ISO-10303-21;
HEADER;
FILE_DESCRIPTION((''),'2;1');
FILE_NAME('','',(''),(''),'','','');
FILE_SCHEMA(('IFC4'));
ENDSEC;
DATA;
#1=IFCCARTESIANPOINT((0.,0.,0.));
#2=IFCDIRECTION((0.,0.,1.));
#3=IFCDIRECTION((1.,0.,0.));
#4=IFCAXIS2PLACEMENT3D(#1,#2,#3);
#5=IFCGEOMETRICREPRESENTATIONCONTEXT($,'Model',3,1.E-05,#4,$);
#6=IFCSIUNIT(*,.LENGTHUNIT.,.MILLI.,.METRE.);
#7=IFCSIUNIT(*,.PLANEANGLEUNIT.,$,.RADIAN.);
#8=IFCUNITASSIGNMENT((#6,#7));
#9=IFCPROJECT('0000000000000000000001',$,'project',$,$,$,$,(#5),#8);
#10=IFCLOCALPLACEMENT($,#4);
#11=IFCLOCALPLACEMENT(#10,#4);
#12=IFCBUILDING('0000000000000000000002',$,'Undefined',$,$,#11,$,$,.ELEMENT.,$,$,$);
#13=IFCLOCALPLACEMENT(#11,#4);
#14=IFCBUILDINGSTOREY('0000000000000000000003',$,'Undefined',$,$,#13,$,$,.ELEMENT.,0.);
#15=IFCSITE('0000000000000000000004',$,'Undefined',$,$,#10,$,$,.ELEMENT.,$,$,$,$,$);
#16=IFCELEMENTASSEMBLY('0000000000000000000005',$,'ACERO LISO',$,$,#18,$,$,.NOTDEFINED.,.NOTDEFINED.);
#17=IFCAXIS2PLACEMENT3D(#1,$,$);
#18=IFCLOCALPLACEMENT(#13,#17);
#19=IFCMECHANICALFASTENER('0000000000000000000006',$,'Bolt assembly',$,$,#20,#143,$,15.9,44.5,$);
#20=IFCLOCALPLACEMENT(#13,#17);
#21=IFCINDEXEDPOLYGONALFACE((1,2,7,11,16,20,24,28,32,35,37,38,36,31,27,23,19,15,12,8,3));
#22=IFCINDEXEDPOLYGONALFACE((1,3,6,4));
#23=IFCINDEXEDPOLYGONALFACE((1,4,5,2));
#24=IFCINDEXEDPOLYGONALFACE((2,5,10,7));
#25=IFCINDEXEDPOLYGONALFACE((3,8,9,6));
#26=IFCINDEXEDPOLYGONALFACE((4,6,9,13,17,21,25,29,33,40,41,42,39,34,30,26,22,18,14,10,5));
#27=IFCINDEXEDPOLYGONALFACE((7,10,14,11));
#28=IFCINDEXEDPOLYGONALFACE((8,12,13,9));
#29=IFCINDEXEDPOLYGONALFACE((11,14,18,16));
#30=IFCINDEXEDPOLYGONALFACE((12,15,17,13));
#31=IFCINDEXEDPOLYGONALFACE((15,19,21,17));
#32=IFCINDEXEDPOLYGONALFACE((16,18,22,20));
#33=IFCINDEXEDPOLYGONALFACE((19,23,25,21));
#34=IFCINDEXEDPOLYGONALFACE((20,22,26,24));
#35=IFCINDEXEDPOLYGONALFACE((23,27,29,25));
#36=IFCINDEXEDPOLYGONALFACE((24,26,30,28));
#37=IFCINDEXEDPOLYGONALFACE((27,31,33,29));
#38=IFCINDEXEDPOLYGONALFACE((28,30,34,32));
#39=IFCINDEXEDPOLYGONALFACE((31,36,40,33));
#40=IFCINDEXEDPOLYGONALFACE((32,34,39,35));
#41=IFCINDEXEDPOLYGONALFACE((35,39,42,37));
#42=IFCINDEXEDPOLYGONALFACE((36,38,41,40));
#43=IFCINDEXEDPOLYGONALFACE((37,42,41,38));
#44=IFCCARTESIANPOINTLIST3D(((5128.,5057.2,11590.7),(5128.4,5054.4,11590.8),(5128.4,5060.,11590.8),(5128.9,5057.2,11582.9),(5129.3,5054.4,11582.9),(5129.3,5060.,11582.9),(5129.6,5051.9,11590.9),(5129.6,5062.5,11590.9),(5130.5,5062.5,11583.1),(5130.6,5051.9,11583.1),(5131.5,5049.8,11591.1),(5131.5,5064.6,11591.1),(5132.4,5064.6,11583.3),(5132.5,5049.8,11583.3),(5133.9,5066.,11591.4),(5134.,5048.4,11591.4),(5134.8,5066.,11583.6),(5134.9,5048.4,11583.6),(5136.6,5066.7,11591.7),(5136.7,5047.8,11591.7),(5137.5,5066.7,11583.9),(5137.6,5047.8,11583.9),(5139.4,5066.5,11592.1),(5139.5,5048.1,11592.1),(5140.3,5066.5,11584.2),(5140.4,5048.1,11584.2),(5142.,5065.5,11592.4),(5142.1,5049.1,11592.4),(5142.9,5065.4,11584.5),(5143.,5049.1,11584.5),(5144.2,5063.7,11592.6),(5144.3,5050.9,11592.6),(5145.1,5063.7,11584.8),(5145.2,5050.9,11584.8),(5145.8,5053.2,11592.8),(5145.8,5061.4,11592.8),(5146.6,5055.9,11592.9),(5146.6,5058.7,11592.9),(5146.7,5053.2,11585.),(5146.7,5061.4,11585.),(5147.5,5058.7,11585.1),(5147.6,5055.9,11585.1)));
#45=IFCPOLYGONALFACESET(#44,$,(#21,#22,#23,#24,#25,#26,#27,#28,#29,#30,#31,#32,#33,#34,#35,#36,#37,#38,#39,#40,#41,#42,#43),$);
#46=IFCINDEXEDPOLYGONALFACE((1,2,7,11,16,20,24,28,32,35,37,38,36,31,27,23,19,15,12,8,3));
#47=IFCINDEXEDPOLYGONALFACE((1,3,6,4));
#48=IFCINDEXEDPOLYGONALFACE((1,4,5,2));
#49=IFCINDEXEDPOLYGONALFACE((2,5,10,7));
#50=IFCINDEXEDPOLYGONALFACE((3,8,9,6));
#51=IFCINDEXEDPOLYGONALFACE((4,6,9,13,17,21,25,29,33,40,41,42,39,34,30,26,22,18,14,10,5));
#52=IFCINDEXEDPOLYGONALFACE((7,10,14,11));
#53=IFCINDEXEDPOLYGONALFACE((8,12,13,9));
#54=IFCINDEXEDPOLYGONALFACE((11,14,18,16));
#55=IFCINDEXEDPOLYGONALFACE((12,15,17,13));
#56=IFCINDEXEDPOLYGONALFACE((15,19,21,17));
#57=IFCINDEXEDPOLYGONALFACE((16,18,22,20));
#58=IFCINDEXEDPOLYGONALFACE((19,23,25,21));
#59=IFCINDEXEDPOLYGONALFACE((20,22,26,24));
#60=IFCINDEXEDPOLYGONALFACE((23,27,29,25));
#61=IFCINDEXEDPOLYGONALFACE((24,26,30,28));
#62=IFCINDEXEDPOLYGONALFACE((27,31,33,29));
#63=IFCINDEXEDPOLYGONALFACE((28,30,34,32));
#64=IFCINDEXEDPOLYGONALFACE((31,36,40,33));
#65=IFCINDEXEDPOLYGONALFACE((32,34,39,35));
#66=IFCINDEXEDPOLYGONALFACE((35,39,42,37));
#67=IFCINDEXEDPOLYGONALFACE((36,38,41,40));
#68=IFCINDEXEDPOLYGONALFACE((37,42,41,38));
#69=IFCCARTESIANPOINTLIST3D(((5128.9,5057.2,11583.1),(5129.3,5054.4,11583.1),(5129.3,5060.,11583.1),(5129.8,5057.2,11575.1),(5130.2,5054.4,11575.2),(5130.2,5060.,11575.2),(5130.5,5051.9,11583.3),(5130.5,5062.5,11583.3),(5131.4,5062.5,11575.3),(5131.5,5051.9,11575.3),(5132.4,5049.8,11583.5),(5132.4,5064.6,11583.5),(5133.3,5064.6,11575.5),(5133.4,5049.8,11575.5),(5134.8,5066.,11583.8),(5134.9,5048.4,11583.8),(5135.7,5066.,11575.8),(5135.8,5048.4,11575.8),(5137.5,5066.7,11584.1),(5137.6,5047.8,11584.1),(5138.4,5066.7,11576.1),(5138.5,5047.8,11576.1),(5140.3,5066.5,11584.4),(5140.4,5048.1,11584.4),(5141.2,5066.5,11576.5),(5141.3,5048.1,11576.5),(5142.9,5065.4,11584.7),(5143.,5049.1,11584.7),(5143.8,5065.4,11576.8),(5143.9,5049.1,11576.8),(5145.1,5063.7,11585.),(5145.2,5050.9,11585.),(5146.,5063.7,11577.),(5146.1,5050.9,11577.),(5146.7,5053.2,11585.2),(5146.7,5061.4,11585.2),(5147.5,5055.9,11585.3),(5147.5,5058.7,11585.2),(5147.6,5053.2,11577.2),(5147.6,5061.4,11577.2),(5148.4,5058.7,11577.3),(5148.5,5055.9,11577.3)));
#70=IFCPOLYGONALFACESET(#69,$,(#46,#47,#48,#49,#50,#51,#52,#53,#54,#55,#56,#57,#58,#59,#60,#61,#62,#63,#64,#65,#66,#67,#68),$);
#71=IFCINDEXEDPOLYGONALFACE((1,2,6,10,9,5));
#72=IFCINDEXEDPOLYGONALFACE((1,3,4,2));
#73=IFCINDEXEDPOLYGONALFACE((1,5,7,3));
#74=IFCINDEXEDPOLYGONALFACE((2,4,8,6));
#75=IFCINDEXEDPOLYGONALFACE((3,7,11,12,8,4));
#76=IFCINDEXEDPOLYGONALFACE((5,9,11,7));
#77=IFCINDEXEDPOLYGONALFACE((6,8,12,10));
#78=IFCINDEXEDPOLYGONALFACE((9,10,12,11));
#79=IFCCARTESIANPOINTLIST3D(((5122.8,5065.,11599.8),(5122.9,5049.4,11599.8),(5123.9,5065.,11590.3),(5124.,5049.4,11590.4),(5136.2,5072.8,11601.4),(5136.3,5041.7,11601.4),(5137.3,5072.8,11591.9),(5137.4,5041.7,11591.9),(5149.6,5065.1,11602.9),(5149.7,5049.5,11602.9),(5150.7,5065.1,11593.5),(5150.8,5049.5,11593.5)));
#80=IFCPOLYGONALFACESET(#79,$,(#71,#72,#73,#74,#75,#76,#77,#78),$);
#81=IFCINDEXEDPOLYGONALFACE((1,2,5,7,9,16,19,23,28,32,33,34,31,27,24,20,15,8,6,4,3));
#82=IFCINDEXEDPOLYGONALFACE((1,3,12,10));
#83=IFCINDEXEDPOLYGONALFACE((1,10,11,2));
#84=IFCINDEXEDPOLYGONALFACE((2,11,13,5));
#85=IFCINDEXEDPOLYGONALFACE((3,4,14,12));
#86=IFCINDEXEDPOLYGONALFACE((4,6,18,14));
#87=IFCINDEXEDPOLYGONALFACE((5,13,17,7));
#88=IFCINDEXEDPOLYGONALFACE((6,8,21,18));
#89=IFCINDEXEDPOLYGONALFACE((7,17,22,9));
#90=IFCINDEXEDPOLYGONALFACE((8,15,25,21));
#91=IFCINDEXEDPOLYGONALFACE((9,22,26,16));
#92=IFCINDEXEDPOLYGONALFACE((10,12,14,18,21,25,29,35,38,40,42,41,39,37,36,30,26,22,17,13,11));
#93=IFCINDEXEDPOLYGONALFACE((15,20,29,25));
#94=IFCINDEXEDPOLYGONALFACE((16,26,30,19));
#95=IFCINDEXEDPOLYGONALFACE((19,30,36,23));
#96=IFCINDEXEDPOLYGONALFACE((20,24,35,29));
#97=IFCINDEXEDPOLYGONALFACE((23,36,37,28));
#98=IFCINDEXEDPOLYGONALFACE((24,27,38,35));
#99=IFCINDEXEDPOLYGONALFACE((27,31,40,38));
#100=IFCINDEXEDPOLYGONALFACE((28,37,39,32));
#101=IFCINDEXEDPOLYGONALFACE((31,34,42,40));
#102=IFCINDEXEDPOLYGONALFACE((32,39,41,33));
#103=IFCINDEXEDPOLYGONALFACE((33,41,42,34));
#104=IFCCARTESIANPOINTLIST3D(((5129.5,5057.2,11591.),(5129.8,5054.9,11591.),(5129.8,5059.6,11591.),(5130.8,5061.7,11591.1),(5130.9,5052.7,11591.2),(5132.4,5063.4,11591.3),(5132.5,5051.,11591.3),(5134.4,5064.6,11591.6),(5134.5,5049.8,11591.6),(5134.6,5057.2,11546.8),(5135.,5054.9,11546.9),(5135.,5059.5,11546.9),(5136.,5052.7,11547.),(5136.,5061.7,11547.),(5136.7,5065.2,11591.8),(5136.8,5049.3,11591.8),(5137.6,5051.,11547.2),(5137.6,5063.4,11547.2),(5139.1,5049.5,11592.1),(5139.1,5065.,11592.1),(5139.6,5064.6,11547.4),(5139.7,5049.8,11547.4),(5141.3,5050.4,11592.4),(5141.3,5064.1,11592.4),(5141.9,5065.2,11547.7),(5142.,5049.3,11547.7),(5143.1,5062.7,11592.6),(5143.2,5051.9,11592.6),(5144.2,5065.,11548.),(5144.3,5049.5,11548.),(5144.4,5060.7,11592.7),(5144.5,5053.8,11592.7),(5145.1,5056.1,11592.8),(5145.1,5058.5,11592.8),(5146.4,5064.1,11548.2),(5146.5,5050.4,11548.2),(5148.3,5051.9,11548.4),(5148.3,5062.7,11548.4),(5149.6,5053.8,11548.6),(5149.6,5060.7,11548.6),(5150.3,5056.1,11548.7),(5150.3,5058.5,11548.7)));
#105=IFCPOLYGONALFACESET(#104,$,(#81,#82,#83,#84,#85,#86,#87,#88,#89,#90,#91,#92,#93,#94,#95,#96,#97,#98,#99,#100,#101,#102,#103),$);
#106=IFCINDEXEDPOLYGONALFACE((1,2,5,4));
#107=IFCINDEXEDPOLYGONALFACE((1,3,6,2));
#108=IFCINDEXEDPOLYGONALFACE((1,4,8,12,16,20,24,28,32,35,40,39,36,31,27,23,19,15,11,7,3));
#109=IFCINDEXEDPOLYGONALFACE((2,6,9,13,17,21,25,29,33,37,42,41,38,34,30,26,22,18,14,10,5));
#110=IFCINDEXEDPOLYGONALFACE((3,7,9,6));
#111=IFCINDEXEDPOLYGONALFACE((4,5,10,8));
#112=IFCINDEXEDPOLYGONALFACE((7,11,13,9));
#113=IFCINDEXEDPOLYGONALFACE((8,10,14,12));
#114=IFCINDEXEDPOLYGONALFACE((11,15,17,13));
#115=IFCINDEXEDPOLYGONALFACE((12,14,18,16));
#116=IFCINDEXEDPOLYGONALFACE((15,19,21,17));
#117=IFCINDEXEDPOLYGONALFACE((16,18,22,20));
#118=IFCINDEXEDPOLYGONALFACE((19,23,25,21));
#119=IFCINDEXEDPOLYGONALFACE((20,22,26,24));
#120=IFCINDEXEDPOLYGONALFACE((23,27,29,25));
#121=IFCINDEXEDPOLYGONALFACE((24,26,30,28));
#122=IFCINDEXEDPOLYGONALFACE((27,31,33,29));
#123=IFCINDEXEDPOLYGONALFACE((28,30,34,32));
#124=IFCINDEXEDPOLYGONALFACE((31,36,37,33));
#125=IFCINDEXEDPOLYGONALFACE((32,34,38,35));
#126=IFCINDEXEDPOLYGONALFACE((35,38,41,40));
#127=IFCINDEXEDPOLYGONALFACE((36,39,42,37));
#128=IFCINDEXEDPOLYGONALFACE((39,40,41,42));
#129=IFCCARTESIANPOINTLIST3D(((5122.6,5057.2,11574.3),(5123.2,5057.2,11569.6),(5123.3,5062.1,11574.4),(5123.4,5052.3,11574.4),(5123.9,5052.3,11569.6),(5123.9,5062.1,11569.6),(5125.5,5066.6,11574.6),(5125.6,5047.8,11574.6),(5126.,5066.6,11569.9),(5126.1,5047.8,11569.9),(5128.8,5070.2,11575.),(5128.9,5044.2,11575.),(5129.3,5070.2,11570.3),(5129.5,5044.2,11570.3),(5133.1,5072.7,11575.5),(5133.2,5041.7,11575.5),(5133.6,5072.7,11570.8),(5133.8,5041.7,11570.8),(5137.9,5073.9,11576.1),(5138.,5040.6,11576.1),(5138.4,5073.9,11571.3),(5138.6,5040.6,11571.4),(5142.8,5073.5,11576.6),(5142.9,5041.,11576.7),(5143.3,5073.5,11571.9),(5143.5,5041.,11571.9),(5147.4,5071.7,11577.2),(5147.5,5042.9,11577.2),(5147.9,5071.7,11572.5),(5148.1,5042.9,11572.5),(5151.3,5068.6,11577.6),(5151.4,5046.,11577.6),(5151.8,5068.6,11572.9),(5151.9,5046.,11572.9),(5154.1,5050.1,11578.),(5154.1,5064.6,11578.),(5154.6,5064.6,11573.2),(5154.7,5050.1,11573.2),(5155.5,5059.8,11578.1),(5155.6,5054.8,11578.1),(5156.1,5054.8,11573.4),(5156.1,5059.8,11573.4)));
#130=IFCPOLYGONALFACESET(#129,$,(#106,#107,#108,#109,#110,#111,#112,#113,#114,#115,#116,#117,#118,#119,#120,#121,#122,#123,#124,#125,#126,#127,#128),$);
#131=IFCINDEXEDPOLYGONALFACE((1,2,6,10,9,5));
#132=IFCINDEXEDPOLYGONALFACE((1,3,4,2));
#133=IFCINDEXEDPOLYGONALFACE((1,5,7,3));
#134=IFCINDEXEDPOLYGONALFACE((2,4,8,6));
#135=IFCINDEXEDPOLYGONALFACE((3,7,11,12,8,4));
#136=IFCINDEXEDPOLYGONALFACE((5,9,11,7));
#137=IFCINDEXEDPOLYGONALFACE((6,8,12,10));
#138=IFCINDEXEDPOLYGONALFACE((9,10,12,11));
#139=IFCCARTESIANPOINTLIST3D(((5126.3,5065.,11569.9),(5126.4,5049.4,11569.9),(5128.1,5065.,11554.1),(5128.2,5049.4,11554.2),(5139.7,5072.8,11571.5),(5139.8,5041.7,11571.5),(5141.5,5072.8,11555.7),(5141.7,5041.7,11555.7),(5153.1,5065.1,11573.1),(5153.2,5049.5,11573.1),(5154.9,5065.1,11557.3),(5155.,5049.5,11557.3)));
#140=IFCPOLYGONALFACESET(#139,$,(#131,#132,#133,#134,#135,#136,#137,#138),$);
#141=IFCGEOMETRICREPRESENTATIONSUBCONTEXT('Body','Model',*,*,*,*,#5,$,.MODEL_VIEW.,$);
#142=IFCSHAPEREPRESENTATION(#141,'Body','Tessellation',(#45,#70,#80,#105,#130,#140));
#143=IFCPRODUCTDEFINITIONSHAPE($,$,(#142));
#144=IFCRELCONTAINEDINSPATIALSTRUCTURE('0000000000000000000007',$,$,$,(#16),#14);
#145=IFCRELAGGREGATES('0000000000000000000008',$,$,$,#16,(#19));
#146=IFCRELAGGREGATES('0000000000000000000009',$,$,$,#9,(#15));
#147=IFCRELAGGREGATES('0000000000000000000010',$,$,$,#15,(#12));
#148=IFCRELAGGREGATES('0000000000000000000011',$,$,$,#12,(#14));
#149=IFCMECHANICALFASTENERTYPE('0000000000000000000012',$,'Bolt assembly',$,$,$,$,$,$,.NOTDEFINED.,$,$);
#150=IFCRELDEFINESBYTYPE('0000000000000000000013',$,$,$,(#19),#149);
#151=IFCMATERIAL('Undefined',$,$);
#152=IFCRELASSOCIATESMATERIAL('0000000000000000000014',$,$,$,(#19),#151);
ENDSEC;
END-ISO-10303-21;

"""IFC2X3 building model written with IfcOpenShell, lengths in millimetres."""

from ifc_helpers import new_model, si_unit, frame, origin_with_axes, origin_2d_with_axis, place, context, subcontext, project, spatial, polyline, circle, outline, extrude, source, transform, mapped, material, type_object, element, aggregate, save


model = new_model("IFC2X3")

# Units and contexts
model_context = context("Model", 3, precision=1e-05, world=origin_with_axes())
body_context = subcontext(model_context, "Body", "Model", "MODEL_VIEW")
ifc_project = project(units=[si_unit("LENGTHUNIT", "METRE", prefix="MILLI"), si_unit("PLANEANGLEUNIT", "RADIAN")], contexts=[model_context])

# Site, building, storey
site_placement = place(None, origin_with_axes())
site = spatial("IfcSite", under=ifc_project, at=site_placement, Name="Undefined", CompositionType="ELEMENT")
building_placement = place(site_placement, origin_with_axes())
building = spatial("IfcBuilding", under=site, at=building_placement, Name="Undefined", CompositionType="ELEMENT")
storey_placement = place(building_placement, origin_with_axes())
storey = spatial("IfcBuildingStorey", under=building, at=storey_placement, Name="Undefined", CompositionType="ELEMENT", Elevation=0.0)

# Element assembly
assembly_1_placement = place(storey_placement, origin_with_axes())
assembly_1 = element("IfcElementAssembly", 1, at=assembly_1_placement, inside=storey, Name="ACERO LISO", AssemblyPlace="NOTDEFINED", PredefinedType="NOTDEFINED")

# Mechanical fastener
ifc_material_1 = material(Name="Undefined")
mechanical_fastener_type = type_object("IfcMechanicalFastenerType", Name="Bolt assembly")
shared_shape_1 = source(origin_with_axes(), body_context, "Body", "SweptSolid", [
    extrude(circle(Radius=9.4, at=origin_2d_with_axis()), frame((0.0, -11.7, 0.0), z_axis=(0.0, 1.0, 0.0), x_axis=(1.0, 0.0, 0.0)), (0.0, 0.0, 1.0), 7.9),
    extrude(circle(Radius=9.4, at=origin_2d_with_axis()), frame((0.0, -4.0, 0.0), z_axis=(0.0, 1.0, 0.0), x_axis=(1.0, 0.0, 0.0)), (0.0, 0.0, 1.0), 8.0),
    extrude(outline(polyline([(13.5, -7.8), (13.5, 7.8), (0.0, 15.6), (-13.5, 7.8), (-13.5, -7.8), (0.0, -15.6), (13.5, -7.8)])), frame((0.0, -21.4, 0.0), z_axis=(0.0, 1.0, 0.0), x_axis=(1.0, 0.0, 0.0)), (0.0, 0.0, 1.0), 9.5),
    extrude(circle(Radius=7.9, at=origin_2d_with_axis()), frame((0.0, -11.8, 0.0), z_axis=(0.0, 1.0, 0.0), x_axis=(1.0, 0.0, 0.0)), (0.0, 0.0, 1.0), 44.5),
    extrude(circle(Radius=16.7, at=origin_2d_with_axis()), frame((0.0, 4.0, 0.0), z_axis=(0.0, 1.0, 0.0), x_axis=(1.0, 0.0, 0.0)), (0.0, 0.0, 1.0), 4.8),
    extrude(outline(polyline([(13.5, -7.8), (13.5, 7.8), (0.0, 15.6), (-13.5, 7.8), (-13.5, -7.8), (0.0, -15.6), (13.5, -7.8)])), frame((0.0, 8.7, 0.0), z_axis=(0.0, 1.0, 0.0), x_axis=(1.0, 0.0, 0.0)), (0.0, 0.0, 1.0), 15.9),
])
mechanical_fastener_1_placement = place(assembly_1_placement, frame((5138.7, 5057.2, 11580.1), z_axis=(-0.862693, 0.495539, -0.101001), x_axis=(0.492195, 0.868586, 0.057474)))
mechanical_fastener_1 = element("IfcMechanicalFastener", 2, at=mechanical_fastener_1_placement, type_object=mechanical_fastener_type, material=ifc_material_1, Name="Bolt assembly", NominalDiameter=15.9, NominalLength=44.5, context=body_context, shape_type="MappedRepresentation", body=[
    mapped(shared_shape_1, transform((0.0, 0.0, 0.0))),
])
aggregate(assembly_1, [mechanical_fastener_1])

save(model, "model.ifc")
